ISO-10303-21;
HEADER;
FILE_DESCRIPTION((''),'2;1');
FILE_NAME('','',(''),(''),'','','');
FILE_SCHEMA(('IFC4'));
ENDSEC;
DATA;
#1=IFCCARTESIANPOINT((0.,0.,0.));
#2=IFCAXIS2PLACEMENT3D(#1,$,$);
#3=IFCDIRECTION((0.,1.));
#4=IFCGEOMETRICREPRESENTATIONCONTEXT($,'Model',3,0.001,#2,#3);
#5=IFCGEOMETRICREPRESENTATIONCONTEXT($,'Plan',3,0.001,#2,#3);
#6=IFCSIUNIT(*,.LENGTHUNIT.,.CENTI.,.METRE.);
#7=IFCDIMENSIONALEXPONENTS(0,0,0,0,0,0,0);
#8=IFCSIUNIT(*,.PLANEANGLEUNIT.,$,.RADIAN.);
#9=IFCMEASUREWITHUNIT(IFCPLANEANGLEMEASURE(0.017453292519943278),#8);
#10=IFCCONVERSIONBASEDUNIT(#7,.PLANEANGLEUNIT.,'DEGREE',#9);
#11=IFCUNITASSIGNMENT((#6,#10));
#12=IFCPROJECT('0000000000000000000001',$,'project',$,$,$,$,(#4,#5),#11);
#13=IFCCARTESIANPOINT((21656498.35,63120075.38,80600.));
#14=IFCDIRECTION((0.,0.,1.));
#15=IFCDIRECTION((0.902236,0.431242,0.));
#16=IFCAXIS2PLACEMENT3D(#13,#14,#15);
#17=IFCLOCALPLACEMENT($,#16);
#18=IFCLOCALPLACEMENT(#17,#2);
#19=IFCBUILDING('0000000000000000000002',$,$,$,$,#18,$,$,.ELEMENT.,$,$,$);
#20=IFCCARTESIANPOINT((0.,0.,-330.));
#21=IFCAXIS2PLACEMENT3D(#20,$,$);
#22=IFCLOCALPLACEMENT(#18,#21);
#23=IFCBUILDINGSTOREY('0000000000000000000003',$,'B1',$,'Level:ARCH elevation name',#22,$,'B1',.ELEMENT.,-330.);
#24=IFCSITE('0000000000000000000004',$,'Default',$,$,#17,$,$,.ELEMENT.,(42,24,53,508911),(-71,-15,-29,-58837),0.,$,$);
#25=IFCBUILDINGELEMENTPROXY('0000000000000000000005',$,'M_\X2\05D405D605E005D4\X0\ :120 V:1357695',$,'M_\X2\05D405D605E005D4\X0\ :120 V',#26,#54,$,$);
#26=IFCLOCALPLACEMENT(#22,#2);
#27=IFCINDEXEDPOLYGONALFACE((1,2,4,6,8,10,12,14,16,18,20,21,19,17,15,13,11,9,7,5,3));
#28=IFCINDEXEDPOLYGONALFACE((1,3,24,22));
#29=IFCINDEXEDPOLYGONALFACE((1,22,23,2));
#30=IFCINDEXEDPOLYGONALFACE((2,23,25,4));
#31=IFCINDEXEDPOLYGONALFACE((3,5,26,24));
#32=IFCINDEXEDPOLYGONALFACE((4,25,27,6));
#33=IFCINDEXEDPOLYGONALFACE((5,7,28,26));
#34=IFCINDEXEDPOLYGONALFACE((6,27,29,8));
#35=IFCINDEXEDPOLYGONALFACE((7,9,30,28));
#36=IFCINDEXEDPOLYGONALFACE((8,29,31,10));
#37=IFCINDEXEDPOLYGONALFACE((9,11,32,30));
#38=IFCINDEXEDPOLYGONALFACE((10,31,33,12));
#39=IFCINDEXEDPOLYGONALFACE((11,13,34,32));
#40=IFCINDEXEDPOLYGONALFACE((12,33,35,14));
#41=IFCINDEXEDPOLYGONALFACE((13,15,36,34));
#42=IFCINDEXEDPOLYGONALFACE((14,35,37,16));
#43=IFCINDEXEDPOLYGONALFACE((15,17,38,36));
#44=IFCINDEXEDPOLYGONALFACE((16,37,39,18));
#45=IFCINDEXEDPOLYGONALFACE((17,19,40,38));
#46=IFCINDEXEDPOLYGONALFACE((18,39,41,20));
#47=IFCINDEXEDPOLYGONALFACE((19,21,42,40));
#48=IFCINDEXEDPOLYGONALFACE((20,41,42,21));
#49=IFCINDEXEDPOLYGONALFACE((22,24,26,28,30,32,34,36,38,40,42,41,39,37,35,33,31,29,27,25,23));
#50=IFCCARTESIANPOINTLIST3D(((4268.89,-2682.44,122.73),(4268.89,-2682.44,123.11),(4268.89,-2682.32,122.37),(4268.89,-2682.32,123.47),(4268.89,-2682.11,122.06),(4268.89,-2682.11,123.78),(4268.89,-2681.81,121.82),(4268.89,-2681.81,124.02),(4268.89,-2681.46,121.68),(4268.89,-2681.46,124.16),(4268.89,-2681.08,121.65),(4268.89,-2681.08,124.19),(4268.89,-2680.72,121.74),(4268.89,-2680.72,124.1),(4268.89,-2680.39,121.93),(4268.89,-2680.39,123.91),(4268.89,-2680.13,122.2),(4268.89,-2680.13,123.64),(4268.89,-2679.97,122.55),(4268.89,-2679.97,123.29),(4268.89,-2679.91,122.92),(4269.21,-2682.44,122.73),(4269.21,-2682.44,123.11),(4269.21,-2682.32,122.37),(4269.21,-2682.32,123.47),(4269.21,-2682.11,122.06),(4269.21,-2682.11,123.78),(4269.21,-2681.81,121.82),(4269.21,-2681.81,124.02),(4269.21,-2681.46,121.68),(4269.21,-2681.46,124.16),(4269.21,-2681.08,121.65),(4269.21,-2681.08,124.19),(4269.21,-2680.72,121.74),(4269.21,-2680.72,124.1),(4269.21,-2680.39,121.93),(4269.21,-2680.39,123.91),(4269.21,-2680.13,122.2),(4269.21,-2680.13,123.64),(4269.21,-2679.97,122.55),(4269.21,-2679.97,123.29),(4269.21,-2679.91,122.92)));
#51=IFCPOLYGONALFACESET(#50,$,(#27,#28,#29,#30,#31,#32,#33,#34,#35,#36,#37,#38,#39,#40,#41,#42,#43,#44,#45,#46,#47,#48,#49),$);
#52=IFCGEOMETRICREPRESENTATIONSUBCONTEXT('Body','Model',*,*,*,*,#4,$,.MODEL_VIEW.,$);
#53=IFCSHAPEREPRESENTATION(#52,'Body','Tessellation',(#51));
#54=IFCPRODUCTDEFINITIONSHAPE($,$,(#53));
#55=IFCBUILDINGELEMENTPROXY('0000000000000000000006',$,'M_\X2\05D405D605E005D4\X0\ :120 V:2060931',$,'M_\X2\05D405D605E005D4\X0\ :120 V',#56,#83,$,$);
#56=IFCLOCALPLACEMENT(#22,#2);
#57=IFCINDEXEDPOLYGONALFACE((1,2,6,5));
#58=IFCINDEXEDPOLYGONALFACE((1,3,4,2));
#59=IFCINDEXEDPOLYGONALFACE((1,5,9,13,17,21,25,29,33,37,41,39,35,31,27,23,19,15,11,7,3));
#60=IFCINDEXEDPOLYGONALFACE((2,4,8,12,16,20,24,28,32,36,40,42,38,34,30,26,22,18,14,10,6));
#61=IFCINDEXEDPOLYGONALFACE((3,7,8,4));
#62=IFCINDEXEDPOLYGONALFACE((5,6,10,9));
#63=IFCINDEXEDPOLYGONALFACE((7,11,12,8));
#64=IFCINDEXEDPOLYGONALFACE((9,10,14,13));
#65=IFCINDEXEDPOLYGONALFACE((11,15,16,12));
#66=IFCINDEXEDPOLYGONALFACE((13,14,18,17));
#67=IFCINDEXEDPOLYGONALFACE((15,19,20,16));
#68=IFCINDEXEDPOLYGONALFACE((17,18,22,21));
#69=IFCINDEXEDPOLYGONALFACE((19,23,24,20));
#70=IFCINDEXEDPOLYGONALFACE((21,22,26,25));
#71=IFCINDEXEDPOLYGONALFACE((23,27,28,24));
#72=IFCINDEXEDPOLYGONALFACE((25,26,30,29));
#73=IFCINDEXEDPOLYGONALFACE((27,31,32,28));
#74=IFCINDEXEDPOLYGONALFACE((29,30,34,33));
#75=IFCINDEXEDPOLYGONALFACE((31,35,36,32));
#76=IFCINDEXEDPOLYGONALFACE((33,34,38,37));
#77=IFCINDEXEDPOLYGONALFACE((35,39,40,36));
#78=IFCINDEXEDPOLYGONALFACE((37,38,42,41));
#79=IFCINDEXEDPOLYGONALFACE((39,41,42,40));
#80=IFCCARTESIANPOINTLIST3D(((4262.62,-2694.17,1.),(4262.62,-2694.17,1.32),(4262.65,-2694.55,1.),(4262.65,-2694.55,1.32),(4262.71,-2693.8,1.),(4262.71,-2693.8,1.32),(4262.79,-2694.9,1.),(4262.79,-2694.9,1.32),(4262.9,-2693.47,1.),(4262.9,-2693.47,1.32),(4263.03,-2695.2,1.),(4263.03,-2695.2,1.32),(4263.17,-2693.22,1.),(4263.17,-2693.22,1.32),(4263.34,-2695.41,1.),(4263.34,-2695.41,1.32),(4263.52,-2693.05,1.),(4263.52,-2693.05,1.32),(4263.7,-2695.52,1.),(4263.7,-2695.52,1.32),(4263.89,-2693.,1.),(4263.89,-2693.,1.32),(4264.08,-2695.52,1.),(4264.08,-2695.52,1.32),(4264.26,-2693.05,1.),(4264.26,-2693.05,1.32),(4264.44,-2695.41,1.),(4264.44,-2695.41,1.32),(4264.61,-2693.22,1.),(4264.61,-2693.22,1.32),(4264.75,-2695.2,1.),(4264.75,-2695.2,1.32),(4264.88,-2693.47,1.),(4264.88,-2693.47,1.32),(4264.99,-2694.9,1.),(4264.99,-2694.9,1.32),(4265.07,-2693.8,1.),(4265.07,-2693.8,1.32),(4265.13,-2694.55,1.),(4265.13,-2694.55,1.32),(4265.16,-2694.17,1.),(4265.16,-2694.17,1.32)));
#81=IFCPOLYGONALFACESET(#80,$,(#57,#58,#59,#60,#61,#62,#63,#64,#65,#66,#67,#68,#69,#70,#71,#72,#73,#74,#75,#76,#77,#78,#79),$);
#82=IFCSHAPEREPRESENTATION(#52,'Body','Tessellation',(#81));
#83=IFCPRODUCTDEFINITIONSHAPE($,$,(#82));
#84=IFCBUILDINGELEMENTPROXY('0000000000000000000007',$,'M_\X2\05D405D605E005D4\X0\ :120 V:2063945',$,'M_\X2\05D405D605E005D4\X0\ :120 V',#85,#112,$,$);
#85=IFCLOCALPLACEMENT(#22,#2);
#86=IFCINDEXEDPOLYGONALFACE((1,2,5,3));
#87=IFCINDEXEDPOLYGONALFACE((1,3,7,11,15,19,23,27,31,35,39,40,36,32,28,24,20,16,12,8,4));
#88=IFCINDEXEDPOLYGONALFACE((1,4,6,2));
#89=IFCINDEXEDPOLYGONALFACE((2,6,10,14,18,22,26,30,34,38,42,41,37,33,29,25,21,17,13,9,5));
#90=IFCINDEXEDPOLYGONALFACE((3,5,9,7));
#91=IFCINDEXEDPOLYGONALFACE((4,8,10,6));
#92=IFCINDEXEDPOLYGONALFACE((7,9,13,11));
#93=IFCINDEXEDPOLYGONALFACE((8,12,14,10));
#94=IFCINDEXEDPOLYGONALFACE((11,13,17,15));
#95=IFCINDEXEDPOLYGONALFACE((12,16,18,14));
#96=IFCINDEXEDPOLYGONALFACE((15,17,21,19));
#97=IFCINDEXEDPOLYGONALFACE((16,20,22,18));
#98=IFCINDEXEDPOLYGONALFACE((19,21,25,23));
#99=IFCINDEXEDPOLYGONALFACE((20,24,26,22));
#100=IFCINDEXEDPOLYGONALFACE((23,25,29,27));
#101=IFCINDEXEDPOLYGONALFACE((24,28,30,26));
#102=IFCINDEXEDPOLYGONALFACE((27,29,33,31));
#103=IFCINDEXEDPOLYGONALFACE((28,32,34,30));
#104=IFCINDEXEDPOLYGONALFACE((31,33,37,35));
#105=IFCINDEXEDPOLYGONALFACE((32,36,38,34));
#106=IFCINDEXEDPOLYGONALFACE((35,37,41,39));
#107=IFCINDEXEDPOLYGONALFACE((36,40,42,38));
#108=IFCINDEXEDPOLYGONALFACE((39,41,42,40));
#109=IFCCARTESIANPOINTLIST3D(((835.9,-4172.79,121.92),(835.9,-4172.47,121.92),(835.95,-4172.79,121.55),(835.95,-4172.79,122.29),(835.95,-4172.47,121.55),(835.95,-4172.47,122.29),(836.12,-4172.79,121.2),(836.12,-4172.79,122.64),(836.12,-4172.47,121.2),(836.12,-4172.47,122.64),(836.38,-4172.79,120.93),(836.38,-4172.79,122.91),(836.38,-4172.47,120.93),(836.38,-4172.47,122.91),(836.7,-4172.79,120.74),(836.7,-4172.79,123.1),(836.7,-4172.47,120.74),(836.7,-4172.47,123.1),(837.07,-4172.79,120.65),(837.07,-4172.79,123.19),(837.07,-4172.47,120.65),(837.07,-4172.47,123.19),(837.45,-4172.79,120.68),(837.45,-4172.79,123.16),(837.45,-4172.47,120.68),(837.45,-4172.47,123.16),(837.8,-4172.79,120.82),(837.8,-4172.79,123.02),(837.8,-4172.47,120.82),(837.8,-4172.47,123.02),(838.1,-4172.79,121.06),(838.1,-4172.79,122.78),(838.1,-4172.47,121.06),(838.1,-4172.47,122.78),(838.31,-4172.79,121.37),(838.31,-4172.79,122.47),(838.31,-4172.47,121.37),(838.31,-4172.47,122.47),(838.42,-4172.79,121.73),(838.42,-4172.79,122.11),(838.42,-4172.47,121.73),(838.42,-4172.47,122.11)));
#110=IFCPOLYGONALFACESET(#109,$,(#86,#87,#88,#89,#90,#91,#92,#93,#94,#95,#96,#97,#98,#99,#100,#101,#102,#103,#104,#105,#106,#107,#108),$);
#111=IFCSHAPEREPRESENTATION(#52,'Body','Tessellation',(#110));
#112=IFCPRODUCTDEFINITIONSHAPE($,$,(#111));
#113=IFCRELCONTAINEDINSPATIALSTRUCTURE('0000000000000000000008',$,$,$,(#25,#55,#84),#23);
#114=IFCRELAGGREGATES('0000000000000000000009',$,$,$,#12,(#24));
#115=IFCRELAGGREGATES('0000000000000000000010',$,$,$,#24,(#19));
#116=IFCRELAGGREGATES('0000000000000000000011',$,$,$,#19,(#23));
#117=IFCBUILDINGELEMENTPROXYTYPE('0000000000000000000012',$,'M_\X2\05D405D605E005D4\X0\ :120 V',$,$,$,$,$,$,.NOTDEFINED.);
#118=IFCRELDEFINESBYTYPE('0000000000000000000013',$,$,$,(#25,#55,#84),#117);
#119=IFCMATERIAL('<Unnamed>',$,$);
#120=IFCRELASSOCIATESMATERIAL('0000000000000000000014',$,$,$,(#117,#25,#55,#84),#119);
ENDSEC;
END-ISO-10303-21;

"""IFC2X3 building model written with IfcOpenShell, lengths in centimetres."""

from ifc_helpers import new_model, entity, si_unit, converted_unit, direction, frame, frame_2d, origin, place, context, subcontext, project, spatial, circle, extrude, source, transform, mapped, material, type_object, type_shapes, element, save


model = new_model("IFC2X3")

# Units and contexts
model_context = context("Model", 3, precision=0.001, world=origin(), true_north=direction((0.0, 1.0)))
plan_context = context("Plan", 3, precision=0.001, world=origin(), true_north=direction((0.0, 1.0)))
body_context = subcontext(model_context, "Body", "Model", "MODEL_VIEW")
ifc_project = project(units=[si_unit("LENGTHUNIT", "METRE", prefix="CENTI"), converted_unit("PLANEANGLEUNIT", "DEGREE", entity("IfcPlaneAngleMeasure", 0.017453292519943278), si_unit("PLANEANGLEUNIT", "RADIAN"), dimensions=[0, 0, 0, 0, 0, 0, 0])], contexts=[model_context, plan_context])

# Site, building, storey
site_placement = place(None, frame((21656498.35, 63120075.38, 80600.0), z_axis=(0.0, 0.0, 1.0), x_axis=(0.902236, 0.431242, 0.0)))
site = spatial("IfcSite", under=ifc_project, at=site_placement, Name="Default", CompositionType="ELEMENT", RefLatitude=(42, 24, 53, 508911), RefLongitude=(-71, -15, -29, -58837), RefElevation=0.0)
building_placement = place(site_placement, origin())
building = spatial("IfcBuilding", under=site, at=building_placement, CompositionType="ELEMENT")
storey_placement = place(building_placement, frame((0.0, 0.0, -330.0)))
storey = spatial("IfcBuildingStorey", under=building, at=storey_placement, Name="B1", ObjectType="Level:ARCH elevation name", LongName="B1", CompositionType="ELEMENT", Elevation=-330.0)

# Building element proxies
ifc_material_1 = material(Name="<Unnamed>")
building_element_proxy_type_1 = type_object("IfcBuildingElementProxyType", Name="M_הזנה :120 V", PredefinedType="NOTDEFINED", material=ifc_material_1)
shared_shape_1 = source(origin(), body_context, "Body", "SweptSolid", [
    extrude(circle(Radius=1.27, at=frame_2d((0.0, 0.0), x_axis=(1.0, 0.0))), origin(), (0.0, 0.0, 1.0), 0.32),
])
type_shapes(building_element_proxy_type_1, [shared_shape_1])
for number, where, z_axis, x_axis, name in (
    (1, (4268.89, -2681.18, 122.92), (1.0, 0.0, 0.0), (0.0, 1.0, 0.0), "M_הזנה :120 V:1357695"),
    (2, (4263.89, -2694.27, 1.0), (0.0, 0.0, 1.0), (0.0, 1.0, 0.0), "M_הזנה :120 V:2060931"),
    (3, (837.17, -4172.79, 121.92), (0.001481, 0.999999, 0.0), (-0.999999, 0.001481, 0.0), "M_הזנה :120 V:2063945"),
):
    element("IfcBuildingElementProxy", number, at=place(storey_placement, frame(where, z_axis=z_axis, x_axis=x_axis)), inside=storey, type_object=building_element_proxy_type_1, material=ifc_material_1, Name=name, ObjectType="M_הזנה :120 V", context=body_context, shape_type="MappedRepresentation", body=[
        mapped(shared_shape_1, transform((0.0, 0.0, 0.0), scale=1.0)),
    ])

save(model, "model.ifc")
